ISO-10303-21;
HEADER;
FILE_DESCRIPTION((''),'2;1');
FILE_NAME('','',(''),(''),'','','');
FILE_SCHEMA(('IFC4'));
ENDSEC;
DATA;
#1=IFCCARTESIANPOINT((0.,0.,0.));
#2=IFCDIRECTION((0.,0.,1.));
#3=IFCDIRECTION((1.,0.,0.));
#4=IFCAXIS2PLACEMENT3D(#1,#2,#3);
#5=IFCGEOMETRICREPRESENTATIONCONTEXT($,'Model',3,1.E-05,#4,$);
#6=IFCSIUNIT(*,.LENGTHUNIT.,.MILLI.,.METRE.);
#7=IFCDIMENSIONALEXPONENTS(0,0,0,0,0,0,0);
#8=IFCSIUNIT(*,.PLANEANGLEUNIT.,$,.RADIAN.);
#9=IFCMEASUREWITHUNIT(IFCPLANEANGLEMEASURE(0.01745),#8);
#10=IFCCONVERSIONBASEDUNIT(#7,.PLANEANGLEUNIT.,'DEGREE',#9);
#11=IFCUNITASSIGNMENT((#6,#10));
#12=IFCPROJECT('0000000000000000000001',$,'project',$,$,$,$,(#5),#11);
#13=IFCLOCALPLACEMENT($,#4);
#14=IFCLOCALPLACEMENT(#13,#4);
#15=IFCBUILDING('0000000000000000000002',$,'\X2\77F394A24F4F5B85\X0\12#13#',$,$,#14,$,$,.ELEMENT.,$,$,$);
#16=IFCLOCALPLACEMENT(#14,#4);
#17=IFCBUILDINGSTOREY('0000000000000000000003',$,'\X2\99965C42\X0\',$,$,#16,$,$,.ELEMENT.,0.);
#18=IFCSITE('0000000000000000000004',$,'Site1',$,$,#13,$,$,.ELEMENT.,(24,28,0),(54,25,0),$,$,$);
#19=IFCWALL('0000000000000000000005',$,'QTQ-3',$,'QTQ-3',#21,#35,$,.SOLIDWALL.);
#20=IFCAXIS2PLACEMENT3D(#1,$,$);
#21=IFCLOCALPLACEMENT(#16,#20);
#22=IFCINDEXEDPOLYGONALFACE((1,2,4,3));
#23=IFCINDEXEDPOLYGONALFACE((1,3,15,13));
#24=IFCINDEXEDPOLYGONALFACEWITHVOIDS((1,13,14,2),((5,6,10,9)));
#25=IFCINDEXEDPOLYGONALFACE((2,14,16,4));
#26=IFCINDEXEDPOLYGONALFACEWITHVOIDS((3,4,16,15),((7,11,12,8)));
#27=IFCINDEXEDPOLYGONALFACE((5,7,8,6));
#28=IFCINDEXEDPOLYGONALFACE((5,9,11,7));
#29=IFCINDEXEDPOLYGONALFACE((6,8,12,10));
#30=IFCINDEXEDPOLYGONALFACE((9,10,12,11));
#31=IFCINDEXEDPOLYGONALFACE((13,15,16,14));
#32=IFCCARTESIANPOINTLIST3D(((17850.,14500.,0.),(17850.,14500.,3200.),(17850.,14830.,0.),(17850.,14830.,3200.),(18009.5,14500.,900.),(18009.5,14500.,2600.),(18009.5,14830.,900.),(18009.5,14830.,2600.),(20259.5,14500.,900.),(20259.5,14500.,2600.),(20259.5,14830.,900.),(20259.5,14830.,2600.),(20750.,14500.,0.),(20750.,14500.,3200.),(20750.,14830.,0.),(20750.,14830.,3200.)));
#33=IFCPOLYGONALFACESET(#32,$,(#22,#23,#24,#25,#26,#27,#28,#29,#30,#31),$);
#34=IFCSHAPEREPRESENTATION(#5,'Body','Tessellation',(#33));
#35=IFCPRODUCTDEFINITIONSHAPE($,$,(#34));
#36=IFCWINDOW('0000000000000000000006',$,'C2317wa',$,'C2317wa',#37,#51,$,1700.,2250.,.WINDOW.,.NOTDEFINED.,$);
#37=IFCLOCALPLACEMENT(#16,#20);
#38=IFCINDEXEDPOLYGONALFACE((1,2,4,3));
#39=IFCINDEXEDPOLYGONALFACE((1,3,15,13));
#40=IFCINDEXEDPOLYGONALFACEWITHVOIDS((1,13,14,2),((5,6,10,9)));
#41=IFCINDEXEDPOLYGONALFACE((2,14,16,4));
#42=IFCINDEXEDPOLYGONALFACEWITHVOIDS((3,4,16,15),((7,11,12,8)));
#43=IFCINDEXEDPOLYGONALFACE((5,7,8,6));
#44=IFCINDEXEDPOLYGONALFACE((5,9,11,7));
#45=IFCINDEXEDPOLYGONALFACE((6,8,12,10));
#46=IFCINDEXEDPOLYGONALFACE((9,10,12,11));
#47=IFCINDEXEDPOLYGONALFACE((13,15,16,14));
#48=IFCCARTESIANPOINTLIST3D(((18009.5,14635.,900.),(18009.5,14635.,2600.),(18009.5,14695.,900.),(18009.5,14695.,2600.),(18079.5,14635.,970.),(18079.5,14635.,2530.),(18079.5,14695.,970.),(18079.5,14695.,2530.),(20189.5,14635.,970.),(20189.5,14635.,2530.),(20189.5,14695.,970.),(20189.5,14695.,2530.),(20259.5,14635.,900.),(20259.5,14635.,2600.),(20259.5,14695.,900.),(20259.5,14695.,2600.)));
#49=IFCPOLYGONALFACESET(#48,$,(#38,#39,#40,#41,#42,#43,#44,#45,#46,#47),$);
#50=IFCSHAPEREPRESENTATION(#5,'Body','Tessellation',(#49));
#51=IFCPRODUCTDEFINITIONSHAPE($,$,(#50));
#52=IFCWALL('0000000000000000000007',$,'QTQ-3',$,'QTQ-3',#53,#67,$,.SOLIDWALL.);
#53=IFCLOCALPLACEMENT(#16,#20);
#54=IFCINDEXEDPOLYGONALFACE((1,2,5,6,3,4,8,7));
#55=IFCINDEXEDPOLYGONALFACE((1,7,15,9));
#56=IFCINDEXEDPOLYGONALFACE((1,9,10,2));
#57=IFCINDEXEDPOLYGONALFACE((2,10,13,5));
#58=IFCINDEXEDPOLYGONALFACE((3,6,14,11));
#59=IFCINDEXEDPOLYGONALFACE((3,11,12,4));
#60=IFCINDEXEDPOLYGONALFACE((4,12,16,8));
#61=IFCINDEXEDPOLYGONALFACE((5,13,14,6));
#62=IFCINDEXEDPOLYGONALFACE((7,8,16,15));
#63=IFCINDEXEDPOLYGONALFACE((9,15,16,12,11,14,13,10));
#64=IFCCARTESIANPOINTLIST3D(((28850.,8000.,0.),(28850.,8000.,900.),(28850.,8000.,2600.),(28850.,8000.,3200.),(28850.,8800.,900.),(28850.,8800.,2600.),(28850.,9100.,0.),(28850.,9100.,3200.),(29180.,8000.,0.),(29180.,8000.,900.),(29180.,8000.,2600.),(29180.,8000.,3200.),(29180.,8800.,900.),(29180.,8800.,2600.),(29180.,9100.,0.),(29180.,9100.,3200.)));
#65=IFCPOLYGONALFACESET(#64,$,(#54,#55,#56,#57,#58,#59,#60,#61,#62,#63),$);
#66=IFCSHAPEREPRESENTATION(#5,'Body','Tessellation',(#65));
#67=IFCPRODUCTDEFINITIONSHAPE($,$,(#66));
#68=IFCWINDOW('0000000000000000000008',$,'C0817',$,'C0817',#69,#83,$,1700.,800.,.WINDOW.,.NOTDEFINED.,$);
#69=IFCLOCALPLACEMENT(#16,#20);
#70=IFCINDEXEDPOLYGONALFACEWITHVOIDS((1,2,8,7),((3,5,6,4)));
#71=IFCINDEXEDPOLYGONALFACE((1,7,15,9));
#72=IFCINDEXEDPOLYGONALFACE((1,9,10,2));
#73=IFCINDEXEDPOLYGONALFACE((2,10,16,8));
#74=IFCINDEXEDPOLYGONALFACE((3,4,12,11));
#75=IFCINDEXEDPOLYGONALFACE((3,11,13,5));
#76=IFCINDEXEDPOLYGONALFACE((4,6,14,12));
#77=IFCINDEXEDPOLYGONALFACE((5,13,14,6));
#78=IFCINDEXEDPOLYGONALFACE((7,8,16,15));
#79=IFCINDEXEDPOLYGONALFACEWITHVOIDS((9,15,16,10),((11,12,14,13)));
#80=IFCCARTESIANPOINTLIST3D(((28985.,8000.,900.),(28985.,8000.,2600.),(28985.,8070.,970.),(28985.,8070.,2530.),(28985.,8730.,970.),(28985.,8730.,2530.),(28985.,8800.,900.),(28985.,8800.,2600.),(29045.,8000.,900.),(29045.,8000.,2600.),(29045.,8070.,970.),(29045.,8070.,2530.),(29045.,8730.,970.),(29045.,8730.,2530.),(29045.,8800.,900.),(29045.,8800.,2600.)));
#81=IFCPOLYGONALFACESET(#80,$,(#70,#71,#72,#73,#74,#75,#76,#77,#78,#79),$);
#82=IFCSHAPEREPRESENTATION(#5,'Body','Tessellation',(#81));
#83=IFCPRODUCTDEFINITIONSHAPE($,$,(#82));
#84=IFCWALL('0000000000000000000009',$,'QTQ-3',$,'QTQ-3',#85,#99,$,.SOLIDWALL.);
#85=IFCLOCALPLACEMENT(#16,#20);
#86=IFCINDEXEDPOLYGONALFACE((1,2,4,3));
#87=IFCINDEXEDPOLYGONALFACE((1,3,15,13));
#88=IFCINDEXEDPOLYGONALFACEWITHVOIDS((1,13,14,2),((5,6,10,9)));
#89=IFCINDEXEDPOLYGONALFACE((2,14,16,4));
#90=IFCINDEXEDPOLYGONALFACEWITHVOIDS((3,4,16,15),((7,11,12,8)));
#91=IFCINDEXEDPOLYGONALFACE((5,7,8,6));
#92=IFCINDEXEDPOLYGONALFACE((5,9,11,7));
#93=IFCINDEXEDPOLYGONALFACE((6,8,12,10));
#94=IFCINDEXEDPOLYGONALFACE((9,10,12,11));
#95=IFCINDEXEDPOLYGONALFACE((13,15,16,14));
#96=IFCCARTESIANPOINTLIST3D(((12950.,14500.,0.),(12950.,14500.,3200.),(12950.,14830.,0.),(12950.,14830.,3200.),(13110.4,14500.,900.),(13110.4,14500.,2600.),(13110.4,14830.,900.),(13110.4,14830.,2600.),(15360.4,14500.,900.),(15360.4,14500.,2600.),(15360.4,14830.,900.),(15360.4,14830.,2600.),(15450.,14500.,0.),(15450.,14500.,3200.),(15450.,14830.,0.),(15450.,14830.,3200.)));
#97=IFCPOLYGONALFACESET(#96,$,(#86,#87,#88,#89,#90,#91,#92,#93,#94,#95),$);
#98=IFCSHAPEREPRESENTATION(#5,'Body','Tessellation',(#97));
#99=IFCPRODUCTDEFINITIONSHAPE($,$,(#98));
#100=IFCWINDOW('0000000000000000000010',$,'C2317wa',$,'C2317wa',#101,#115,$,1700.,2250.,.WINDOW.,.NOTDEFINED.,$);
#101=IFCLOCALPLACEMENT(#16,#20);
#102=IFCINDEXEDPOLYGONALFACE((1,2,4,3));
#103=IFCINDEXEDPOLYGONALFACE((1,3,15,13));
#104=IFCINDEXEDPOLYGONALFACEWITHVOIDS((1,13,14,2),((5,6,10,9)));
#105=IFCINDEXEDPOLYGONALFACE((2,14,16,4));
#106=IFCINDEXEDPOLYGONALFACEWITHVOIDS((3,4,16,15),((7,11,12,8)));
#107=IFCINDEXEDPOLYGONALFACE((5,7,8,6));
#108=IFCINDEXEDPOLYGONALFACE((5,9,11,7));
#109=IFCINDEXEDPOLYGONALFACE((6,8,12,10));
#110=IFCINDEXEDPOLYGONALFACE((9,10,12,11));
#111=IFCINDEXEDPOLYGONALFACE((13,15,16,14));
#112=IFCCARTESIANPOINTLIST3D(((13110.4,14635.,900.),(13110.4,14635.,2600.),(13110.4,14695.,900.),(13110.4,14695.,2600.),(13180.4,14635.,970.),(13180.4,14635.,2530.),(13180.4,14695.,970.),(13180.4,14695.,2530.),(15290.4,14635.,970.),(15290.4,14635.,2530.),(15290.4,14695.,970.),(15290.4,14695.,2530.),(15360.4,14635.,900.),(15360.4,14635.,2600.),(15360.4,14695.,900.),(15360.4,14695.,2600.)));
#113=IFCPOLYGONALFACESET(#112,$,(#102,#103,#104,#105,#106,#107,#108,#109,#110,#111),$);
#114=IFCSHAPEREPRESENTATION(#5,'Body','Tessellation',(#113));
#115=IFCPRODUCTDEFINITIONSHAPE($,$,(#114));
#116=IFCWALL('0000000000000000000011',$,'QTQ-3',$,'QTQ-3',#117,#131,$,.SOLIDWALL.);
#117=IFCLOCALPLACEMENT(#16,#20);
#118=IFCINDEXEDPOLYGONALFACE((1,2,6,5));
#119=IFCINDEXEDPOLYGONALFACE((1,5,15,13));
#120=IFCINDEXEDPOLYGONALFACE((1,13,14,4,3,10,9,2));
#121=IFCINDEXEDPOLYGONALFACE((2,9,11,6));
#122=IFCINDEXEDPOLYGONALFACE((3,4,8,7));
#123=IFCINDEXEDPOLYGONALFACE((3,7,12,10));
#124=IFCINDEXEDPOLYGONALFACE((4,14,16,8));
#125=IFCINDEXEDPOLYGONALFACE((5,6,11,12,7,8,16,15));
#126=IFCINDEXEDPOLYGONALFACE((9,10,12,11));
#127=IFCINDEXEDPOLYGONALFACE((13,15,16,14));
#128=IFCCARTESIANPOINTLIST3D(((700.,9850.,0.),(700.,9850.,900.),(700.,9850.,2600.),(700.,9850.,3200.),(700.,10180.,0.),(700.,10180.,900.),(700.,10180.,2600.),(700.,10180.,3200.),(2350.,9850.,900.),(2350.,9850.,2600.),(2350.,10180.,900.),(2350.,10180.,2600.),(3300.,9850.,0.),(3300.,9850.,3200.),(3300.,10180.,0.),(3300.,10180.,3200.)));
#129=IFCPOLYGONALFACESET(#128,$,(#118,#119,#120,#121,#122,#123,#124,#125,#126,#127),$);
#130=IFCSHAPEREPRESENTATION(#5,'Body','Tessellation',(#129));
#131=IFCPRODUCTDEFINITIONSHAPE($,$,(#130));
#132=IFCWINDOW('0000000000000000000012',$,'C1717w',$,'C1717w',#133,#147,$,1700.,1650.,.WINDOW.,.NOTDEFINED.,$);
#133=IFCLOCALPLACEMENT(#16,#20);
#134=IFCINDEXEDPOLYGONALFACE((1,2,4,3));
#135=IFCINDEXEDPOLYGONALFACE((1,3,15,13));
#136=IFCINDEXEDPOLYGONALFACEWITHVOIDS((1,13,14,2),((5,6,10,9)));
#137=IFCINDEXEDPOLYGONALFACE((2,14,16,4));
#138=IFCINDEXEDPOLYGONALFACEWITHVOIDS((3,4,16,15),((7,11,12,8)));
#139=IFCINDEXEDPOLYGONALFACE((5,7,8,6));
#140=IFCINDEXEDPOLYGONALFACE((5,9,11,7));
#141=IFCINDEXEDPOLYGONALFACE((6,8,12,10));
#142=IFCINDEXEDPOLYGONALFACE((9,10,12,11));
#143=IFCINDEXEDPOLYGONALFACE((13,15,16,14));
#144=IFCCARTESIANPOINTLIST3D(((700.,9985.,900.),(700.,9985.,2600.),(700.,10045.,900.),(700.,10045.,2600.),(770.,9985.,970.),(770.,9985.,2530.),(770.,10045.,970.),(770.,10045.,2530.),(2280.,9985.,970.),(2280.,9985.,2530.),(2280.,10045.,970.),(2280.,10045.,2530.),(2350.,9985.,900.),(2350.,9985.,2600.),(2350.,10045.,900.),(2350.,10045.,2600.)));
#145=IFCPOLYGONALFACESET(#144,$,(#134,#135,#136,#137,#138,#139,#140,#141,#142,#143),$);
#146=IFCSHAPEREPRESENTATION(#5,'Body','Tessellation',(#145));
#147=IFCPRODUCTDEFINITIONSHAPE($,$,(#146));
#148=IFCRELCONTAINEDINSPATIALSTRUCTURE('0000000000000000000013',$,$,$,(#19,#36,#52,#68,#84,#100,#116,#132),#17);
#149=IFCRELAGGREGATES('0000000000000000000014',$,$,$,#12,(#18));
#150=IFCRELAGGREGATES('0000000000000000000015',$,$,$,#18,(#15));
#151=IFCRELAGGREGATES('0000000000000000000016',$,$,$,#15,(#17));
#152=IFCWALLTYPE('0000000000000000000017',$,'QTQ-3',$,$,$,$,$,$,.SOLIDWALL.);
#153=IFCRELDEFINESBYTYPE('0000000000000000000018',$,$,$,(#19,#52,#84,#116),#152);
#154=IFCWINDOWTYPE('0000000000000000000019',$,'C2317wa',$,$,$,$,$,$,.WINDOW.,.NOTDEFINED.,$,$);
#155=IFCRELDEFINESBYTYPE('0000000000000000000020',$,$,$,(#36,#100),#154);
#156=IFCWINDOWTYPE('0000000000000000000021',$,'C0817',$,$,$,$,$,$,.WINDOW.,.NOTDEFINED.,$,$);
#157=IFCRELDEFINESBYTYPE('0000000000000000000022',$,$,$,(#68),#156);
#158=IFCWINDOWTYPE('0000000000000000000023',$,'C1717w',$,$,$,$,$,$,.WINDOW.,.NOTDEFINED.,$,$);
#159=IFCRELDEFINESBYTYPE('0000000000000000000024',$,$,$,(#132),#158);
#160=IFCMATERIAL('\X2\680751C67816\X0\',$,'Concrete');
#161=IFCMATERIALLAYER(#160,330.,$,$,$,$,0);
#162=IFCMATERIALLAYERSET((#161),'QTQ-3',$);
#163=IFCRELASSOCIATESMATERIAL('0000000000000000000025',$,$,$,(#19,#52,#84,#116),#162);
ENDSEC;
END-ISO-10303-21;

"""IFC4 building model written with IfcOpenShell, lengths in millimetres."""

from ifc_helpers import new_model, entity, si_unit, converted_unit, frame, origin_with_axes, place, context, project, spatial, polyline, outline, extrude, material, layer, layer_set, type_object, element, fill, save


model = new_model("IFC4")

# Units and contexts
model_context = context("Model", 3, precision=1e-05, world=origin_with_axes())
ifc_project = project(units=[si_unit("LENGTHUNIT", "METRE", prefix="MILLI"), converted_unit("PLANEANGLEUNIT", "DEGREE", entity("IfcPlaneAngleMeasure", 0.01745), si_unit("PLANEANGLEUNIT", "RADIAN"), dimensions=[0, 0, 0, 0, 0, 0, 0])], contexts=[model_context])

# Site, building, storey
site_placement = place(None, origin_with_axes())
site = spatial("IfcSite", under=ifc_project, at=site_placement, Name="Site1", CompositionType="ELEMENT", RefLatitude=(24, 28, 0), RefLongitude=(54, 25, 0))
building_placement = place(site_placement, origin_with_axes())
building = spatial("IfcBuilding", under=site, at=building_placement, Name="石钢住宅12#13#", CompositionType="ELEMENT")
storey_placement = place(building_placement, origin_with_axes())
storey = spatial("IfcBuildingStorey", under=building, at=storey_placement, Name="首层", CompositionType="ELEMENT", Elevation=0.0)

# Shared definitions
ifc_material = material(Name="标准砖", Category="Concrete")
ifc_layer = layer(ifc_material, 330.0, Priority=0)
ifc_layer_set = layer_set([ifc_layer], Name="QTQ-3")
wall_type = type_object("IfcWallType", Name="QTQ-3", PredefinedType="SOLIDWALL")

# Walls, openings, windows
wall_1_placement = place(storey_placement, origin_with_axes())
wall_1 = element("IfcWall", 1, at=wall_1_placement, inside=storey, type_object=wall_type, material=ifc_layer_set, Name="QTQ-3", ObjectType="QTQ-3", PredefinedType="SOLIDWALL", context=model_context, shape_type="SweptSolid", body=[
    extrude(outline(polyline([(0.0, 0.0), (3200.0, 0.0), (3200.0, 2900.0), (0.0, 2900.0), (0.0, 0.0)])), frame((17850.0, 14830.0, 3200.0), z_axis=(0.0, -1.0, 0.0), x_axis=(0.0, 0.0, -1.0)), (0.0, 0.0, 1.0), 330.0),
])
opening_1_placement = place(storey_placement, origin_with_axes())
opening_1 = element("IfcOpeningElement", 2, at=opening_1_placement, cuts=wall_1, PredefinedType="OPENING", context=model_context, shape_type="SweptSolid", body=[
    extrude(outline(polyline([(0.0, 0.0), (2250.0, 0.0), (2250.0, 1700.0), (0.0, 1700.0), (0.0, 0.0)])), frame((18009.5, 15830.0, 900.0), z_axis=(0.0, -1.0, 0.0), x_axis=(1.0, 0.0, 0.0)), (0.0, 0.0, 1.0), 2330.0),
])
window_type_1 = type_object("IfcWindowType", Name="C2317wa", PartitioningType="NOTDEFINED", PredefinedType="WINDOW")
window_1_placement = place(storey_placement, origin_with_axes())
window_1 = element("IfcWindow", 3, at=window_1_placement, inside=storey, type_object=window_type_1, Name="C2317wa", ObjectType="C2317wa", OverallHeight=1700.0, OverallWidth=2250.0, PartitioningType="NOTDEFINED", PredefinedType="WINDOW", context=model_context, shape_type="SweptSolid", body=[
    extrude(outline(polyline([(-1125.0, -850.0), (1125.0, -850.0), (1125.0, 850.0), (-1125.0, 850.0), (-1125.0, -850.0)]), holes=[polyline([(-1055.0, -780.0), (-1055.0, 780.0), (1055.0, 780.0), (1055.0, -780.0), (-1055.0, -780.0)])]), frame((19134.5, 14695.0, 1750.0), z_axis=(0.0, -1.0, 0.0), x_axis=(1.0, 0.0, 0.0)), (0.0, 0.0, 1.0), 60.0),
])
fill(opening_1, window_1)
wall_2_placement = place(storey_placement, origin_with_axes())
wall_2 = element("IfcWall", 4, at=wall_2_placement, inside=storey, type_object=wall_type, material=ifc_layer_set, Name="QTQ-3", ObjectType="QTQ-3", PredefinedType="SOLIDWALL", context=model_context, shape_type="SweptSolid", body=[
    extrude(outline(polyline([(0.0, 0.0), (3200.0, 0.0), (3200.0, 1100.0), (0.0, 1100.0), (0.0, 0.0)])), frame((29180.0, 9100.0, 3200.0), z_axis=(-1.0, 0.0, 0.0), x_axis=(0.0, 0.0, -1.0)), (0.0, 0.0, 1.0), 330.0),
])
opening_2_placement = place(storey_placement, origin_with_axes())
opening_2 = element("IfcOpeningElement", 5, at=opening_2_placement, cuts=wall_2, PredefinedType="OPENING", context=model_context, shape_type="SweptSolid", body=[
    extrude(outline(polyline([(0.0, 0.0), (800.0, 0.0), (800.0, 1700.0), (0.0, 1700.0), (0.0, 0.0)])), frame((30180.0, 8800.0, 900.0), z_axis=(-1.0, 0.0, 0.0), x_axis=(0.0, -1.0, 0.0)), (0.0, 0.0, 1.0), 2330.0),
])
window_type_2 = type_object("IfcWindowType", Name="C0817", PartitioningType="NOTDEFINED", PredefinedType="WINDOW")
window_2_placement = place(storey_placement, origin_with_axes())
window_2 = element("IfcWindow", 6, at=window_2_placement, inside=storey, type_object=window_type_2, Name="C0817", ObjectType="C0817", OverallHeight=1700.0, OverallWidth=800.0, PartitioningType="NOTDEFINED", PredefinedType="WINDOW", context=model_context, shape_type="SweptSolid", body=[
    extrude(outline(polyline([(-400.0, -850.0), (400.0, -850.0), (400.0, 850.0), (-400.0, 850.0), (-400.0, -850.0)]), holes=[polyline([(-330.0, -780.0), (-330.0, 780.0), (330.0, 780.0), (330.0, -780.0), (-330.0, -780.0)])]), frame((29045.0, 8400.0, 1750.0), z_axis=(-1.0, 0.0, 0.0), x_axis=(0.0, -1.0, 0.0)), (0.0, 0.0, 1.0), 60.0),
])
fill(opening_2, window_2)
wall_3_placement = place(storey_placement, origin_with_axes())
wall_3 = element("IfcWall", 7, at=wall_3_placement, inside=storey, type_object=wall_type, material=ifc_layer_set, Name="QTQ-3", ObjectType="QTQ-3", PredefinedType="SOLIDWALL", context=model_context, shape_type="SweptSolid", body=[
    extrude(outline(polyline([(0.0, 0.0), (3200.0, 0.0), (3200.0, 2500.0), (0.0, 2500.0), (0.0, 0.0)])), frame((15450.0, 14500.0, 3200.0), z_axis=(0.0, 1.0, 0.0), x_axis=(0.0, 0.0, -1.0)), (0.0, 0.0, 1.0), 330.0),
])
opening_3_placement = place(storey_placement, origin_with_axes())
opening_3 = element("IfcOpeningElement", 8, at=opening_3_placement, cuts=wall_3, PredefinedType="OPENING", context=model_context, shape_type="SweptSolid", body=[
    extrude(outline(polyline([(0.0, 0.0), (2250.0, 0.0), (2250.0, 1700.0), (0.0, 1700.0), (0.0, 0.0)])), frame((15360.4, 13500.0, 900.0), z_axis=(0.0, 1.0, 0.0), x_axis=(-1.0, 0.0, 0.0)), (0.0, 0.0, 1.0), 2330.0),
])
window_3_placement = place(storey_placement, origin_with_axes())
window_3 = element("IfcWindow", 9, at=window_3_placement, inside=storey, type_object=window_type_1, Name="C2317wa", ObjectType="C2317wa", OverallHeight=1700.0, OverallWidth=2250.0, PartitioningType="NOTDEFINED", PredefinedType="WINDOW", context=model_context, shape_type="SweptSolid", body=[
    extrude(outline(polyline([(-1125.0, -850.0), (1125.0, -850.0), (1125.0, 850.0), (-1125.0, 850.0), (-1125.0, -850.0)]), holes=[polyline([(-1055.0, -780.0), (-1055.0, 780.0), (1055.0, 780.0), (1055.0, -780.0), (-1055.0, -780.0)])]), frame((14235.4, 14635.0, 1750.0), z_axis=(0.0, 1.0, 0.0), x_axis=(-1.0, 0.0, 0.0)), (0.0, 0.0, 1.0), 60.0),
])
fill(opening_3, window_3)
wall_4_placement = place(storey_placement, origin_with_axes())
wall_4 = element("IfcWall", 10, at=wall_4_placement, inside=storey, type_object=wall_type, material=ifc_layer_set, Name="QTQ-3", ObjectType="QTQ-3", PredefinedType="SOLIDWALL", context=model_context, shape_type="SweptSolid", body=[
    extrude(outline(polyline([(0.0, 0.0), (3200.0, 0.0), (3200.0, 2600.0), (0.0, 2600.0), (0.0, 0.0)])), frame((700.0, 10180.0, 3200.0), z_axis=(0.0, -1.0, 0.0), x_axis=(0.0, 0.0, -1.0)), (0.0, 0.0, 1.0), 330.0),
])
opening_4_placement = place(storey_placement, origin_with_axes())
opening_4 = element("IfcOpeningElement", 11, at=opening_4_placement, cuts=wall_4, PredefinedType="OPENING", context=model_context, shape_type="SweptSolid", body=[
    extrude(outline(polyline([(0.0, 0.0), (1650.0, 0.0), (1650.0, 1700.0), (0.0, 1700.0), (0.0, 0.0)])), frame((700.0, 11180.0, 900.0), z_axis=(0.0, -1.0, 0.0), x_axis=(1.0, 0.0, 0.0)), (0.0, 0.0, 1.0), 2330.0),
])
window_type_3 = type_object("IfcWindowType", Name="C1717w", PartitioningType="NOTDEFINED", PredefinedType="WINDOW")
window_4_placement = place(storey_placement, origin_with_axes())
window_4 = element("IfcWindow", 12, at=window_4_placement, inside=storey, type_object=window_type_3, Name="C1717w", ObjectType="C1717w", OverallHeight=1700.0, OverallWidth=1650.0, PartitioningType="NOTDEFINED", PredefinedType="WINDOW", context=model_context, shape_type="SweptSolid", body=[
    extrude(outline(polyline([(-825.0, -850.0), (825.0, -850.0), (825.0, 850.0), (-825.0, 850.0), (-825.0, -850.0)]), holes=[polyline([(-755.0, -780.0), (-755.0, 780.0), (755.0, 780.0), (755.0, -780.0), (-755.0, -780.0)])]), frame((1525.0, 10045.0, 1750.0), z_axis=(0.0, -1.0, 0.0), x_axis=(1.0, 0.0, 0.0)), (0.0, 0.0, 1.0), 60.0),
])
fill(opening_4, window_4)

save(model, "model.ifc")
